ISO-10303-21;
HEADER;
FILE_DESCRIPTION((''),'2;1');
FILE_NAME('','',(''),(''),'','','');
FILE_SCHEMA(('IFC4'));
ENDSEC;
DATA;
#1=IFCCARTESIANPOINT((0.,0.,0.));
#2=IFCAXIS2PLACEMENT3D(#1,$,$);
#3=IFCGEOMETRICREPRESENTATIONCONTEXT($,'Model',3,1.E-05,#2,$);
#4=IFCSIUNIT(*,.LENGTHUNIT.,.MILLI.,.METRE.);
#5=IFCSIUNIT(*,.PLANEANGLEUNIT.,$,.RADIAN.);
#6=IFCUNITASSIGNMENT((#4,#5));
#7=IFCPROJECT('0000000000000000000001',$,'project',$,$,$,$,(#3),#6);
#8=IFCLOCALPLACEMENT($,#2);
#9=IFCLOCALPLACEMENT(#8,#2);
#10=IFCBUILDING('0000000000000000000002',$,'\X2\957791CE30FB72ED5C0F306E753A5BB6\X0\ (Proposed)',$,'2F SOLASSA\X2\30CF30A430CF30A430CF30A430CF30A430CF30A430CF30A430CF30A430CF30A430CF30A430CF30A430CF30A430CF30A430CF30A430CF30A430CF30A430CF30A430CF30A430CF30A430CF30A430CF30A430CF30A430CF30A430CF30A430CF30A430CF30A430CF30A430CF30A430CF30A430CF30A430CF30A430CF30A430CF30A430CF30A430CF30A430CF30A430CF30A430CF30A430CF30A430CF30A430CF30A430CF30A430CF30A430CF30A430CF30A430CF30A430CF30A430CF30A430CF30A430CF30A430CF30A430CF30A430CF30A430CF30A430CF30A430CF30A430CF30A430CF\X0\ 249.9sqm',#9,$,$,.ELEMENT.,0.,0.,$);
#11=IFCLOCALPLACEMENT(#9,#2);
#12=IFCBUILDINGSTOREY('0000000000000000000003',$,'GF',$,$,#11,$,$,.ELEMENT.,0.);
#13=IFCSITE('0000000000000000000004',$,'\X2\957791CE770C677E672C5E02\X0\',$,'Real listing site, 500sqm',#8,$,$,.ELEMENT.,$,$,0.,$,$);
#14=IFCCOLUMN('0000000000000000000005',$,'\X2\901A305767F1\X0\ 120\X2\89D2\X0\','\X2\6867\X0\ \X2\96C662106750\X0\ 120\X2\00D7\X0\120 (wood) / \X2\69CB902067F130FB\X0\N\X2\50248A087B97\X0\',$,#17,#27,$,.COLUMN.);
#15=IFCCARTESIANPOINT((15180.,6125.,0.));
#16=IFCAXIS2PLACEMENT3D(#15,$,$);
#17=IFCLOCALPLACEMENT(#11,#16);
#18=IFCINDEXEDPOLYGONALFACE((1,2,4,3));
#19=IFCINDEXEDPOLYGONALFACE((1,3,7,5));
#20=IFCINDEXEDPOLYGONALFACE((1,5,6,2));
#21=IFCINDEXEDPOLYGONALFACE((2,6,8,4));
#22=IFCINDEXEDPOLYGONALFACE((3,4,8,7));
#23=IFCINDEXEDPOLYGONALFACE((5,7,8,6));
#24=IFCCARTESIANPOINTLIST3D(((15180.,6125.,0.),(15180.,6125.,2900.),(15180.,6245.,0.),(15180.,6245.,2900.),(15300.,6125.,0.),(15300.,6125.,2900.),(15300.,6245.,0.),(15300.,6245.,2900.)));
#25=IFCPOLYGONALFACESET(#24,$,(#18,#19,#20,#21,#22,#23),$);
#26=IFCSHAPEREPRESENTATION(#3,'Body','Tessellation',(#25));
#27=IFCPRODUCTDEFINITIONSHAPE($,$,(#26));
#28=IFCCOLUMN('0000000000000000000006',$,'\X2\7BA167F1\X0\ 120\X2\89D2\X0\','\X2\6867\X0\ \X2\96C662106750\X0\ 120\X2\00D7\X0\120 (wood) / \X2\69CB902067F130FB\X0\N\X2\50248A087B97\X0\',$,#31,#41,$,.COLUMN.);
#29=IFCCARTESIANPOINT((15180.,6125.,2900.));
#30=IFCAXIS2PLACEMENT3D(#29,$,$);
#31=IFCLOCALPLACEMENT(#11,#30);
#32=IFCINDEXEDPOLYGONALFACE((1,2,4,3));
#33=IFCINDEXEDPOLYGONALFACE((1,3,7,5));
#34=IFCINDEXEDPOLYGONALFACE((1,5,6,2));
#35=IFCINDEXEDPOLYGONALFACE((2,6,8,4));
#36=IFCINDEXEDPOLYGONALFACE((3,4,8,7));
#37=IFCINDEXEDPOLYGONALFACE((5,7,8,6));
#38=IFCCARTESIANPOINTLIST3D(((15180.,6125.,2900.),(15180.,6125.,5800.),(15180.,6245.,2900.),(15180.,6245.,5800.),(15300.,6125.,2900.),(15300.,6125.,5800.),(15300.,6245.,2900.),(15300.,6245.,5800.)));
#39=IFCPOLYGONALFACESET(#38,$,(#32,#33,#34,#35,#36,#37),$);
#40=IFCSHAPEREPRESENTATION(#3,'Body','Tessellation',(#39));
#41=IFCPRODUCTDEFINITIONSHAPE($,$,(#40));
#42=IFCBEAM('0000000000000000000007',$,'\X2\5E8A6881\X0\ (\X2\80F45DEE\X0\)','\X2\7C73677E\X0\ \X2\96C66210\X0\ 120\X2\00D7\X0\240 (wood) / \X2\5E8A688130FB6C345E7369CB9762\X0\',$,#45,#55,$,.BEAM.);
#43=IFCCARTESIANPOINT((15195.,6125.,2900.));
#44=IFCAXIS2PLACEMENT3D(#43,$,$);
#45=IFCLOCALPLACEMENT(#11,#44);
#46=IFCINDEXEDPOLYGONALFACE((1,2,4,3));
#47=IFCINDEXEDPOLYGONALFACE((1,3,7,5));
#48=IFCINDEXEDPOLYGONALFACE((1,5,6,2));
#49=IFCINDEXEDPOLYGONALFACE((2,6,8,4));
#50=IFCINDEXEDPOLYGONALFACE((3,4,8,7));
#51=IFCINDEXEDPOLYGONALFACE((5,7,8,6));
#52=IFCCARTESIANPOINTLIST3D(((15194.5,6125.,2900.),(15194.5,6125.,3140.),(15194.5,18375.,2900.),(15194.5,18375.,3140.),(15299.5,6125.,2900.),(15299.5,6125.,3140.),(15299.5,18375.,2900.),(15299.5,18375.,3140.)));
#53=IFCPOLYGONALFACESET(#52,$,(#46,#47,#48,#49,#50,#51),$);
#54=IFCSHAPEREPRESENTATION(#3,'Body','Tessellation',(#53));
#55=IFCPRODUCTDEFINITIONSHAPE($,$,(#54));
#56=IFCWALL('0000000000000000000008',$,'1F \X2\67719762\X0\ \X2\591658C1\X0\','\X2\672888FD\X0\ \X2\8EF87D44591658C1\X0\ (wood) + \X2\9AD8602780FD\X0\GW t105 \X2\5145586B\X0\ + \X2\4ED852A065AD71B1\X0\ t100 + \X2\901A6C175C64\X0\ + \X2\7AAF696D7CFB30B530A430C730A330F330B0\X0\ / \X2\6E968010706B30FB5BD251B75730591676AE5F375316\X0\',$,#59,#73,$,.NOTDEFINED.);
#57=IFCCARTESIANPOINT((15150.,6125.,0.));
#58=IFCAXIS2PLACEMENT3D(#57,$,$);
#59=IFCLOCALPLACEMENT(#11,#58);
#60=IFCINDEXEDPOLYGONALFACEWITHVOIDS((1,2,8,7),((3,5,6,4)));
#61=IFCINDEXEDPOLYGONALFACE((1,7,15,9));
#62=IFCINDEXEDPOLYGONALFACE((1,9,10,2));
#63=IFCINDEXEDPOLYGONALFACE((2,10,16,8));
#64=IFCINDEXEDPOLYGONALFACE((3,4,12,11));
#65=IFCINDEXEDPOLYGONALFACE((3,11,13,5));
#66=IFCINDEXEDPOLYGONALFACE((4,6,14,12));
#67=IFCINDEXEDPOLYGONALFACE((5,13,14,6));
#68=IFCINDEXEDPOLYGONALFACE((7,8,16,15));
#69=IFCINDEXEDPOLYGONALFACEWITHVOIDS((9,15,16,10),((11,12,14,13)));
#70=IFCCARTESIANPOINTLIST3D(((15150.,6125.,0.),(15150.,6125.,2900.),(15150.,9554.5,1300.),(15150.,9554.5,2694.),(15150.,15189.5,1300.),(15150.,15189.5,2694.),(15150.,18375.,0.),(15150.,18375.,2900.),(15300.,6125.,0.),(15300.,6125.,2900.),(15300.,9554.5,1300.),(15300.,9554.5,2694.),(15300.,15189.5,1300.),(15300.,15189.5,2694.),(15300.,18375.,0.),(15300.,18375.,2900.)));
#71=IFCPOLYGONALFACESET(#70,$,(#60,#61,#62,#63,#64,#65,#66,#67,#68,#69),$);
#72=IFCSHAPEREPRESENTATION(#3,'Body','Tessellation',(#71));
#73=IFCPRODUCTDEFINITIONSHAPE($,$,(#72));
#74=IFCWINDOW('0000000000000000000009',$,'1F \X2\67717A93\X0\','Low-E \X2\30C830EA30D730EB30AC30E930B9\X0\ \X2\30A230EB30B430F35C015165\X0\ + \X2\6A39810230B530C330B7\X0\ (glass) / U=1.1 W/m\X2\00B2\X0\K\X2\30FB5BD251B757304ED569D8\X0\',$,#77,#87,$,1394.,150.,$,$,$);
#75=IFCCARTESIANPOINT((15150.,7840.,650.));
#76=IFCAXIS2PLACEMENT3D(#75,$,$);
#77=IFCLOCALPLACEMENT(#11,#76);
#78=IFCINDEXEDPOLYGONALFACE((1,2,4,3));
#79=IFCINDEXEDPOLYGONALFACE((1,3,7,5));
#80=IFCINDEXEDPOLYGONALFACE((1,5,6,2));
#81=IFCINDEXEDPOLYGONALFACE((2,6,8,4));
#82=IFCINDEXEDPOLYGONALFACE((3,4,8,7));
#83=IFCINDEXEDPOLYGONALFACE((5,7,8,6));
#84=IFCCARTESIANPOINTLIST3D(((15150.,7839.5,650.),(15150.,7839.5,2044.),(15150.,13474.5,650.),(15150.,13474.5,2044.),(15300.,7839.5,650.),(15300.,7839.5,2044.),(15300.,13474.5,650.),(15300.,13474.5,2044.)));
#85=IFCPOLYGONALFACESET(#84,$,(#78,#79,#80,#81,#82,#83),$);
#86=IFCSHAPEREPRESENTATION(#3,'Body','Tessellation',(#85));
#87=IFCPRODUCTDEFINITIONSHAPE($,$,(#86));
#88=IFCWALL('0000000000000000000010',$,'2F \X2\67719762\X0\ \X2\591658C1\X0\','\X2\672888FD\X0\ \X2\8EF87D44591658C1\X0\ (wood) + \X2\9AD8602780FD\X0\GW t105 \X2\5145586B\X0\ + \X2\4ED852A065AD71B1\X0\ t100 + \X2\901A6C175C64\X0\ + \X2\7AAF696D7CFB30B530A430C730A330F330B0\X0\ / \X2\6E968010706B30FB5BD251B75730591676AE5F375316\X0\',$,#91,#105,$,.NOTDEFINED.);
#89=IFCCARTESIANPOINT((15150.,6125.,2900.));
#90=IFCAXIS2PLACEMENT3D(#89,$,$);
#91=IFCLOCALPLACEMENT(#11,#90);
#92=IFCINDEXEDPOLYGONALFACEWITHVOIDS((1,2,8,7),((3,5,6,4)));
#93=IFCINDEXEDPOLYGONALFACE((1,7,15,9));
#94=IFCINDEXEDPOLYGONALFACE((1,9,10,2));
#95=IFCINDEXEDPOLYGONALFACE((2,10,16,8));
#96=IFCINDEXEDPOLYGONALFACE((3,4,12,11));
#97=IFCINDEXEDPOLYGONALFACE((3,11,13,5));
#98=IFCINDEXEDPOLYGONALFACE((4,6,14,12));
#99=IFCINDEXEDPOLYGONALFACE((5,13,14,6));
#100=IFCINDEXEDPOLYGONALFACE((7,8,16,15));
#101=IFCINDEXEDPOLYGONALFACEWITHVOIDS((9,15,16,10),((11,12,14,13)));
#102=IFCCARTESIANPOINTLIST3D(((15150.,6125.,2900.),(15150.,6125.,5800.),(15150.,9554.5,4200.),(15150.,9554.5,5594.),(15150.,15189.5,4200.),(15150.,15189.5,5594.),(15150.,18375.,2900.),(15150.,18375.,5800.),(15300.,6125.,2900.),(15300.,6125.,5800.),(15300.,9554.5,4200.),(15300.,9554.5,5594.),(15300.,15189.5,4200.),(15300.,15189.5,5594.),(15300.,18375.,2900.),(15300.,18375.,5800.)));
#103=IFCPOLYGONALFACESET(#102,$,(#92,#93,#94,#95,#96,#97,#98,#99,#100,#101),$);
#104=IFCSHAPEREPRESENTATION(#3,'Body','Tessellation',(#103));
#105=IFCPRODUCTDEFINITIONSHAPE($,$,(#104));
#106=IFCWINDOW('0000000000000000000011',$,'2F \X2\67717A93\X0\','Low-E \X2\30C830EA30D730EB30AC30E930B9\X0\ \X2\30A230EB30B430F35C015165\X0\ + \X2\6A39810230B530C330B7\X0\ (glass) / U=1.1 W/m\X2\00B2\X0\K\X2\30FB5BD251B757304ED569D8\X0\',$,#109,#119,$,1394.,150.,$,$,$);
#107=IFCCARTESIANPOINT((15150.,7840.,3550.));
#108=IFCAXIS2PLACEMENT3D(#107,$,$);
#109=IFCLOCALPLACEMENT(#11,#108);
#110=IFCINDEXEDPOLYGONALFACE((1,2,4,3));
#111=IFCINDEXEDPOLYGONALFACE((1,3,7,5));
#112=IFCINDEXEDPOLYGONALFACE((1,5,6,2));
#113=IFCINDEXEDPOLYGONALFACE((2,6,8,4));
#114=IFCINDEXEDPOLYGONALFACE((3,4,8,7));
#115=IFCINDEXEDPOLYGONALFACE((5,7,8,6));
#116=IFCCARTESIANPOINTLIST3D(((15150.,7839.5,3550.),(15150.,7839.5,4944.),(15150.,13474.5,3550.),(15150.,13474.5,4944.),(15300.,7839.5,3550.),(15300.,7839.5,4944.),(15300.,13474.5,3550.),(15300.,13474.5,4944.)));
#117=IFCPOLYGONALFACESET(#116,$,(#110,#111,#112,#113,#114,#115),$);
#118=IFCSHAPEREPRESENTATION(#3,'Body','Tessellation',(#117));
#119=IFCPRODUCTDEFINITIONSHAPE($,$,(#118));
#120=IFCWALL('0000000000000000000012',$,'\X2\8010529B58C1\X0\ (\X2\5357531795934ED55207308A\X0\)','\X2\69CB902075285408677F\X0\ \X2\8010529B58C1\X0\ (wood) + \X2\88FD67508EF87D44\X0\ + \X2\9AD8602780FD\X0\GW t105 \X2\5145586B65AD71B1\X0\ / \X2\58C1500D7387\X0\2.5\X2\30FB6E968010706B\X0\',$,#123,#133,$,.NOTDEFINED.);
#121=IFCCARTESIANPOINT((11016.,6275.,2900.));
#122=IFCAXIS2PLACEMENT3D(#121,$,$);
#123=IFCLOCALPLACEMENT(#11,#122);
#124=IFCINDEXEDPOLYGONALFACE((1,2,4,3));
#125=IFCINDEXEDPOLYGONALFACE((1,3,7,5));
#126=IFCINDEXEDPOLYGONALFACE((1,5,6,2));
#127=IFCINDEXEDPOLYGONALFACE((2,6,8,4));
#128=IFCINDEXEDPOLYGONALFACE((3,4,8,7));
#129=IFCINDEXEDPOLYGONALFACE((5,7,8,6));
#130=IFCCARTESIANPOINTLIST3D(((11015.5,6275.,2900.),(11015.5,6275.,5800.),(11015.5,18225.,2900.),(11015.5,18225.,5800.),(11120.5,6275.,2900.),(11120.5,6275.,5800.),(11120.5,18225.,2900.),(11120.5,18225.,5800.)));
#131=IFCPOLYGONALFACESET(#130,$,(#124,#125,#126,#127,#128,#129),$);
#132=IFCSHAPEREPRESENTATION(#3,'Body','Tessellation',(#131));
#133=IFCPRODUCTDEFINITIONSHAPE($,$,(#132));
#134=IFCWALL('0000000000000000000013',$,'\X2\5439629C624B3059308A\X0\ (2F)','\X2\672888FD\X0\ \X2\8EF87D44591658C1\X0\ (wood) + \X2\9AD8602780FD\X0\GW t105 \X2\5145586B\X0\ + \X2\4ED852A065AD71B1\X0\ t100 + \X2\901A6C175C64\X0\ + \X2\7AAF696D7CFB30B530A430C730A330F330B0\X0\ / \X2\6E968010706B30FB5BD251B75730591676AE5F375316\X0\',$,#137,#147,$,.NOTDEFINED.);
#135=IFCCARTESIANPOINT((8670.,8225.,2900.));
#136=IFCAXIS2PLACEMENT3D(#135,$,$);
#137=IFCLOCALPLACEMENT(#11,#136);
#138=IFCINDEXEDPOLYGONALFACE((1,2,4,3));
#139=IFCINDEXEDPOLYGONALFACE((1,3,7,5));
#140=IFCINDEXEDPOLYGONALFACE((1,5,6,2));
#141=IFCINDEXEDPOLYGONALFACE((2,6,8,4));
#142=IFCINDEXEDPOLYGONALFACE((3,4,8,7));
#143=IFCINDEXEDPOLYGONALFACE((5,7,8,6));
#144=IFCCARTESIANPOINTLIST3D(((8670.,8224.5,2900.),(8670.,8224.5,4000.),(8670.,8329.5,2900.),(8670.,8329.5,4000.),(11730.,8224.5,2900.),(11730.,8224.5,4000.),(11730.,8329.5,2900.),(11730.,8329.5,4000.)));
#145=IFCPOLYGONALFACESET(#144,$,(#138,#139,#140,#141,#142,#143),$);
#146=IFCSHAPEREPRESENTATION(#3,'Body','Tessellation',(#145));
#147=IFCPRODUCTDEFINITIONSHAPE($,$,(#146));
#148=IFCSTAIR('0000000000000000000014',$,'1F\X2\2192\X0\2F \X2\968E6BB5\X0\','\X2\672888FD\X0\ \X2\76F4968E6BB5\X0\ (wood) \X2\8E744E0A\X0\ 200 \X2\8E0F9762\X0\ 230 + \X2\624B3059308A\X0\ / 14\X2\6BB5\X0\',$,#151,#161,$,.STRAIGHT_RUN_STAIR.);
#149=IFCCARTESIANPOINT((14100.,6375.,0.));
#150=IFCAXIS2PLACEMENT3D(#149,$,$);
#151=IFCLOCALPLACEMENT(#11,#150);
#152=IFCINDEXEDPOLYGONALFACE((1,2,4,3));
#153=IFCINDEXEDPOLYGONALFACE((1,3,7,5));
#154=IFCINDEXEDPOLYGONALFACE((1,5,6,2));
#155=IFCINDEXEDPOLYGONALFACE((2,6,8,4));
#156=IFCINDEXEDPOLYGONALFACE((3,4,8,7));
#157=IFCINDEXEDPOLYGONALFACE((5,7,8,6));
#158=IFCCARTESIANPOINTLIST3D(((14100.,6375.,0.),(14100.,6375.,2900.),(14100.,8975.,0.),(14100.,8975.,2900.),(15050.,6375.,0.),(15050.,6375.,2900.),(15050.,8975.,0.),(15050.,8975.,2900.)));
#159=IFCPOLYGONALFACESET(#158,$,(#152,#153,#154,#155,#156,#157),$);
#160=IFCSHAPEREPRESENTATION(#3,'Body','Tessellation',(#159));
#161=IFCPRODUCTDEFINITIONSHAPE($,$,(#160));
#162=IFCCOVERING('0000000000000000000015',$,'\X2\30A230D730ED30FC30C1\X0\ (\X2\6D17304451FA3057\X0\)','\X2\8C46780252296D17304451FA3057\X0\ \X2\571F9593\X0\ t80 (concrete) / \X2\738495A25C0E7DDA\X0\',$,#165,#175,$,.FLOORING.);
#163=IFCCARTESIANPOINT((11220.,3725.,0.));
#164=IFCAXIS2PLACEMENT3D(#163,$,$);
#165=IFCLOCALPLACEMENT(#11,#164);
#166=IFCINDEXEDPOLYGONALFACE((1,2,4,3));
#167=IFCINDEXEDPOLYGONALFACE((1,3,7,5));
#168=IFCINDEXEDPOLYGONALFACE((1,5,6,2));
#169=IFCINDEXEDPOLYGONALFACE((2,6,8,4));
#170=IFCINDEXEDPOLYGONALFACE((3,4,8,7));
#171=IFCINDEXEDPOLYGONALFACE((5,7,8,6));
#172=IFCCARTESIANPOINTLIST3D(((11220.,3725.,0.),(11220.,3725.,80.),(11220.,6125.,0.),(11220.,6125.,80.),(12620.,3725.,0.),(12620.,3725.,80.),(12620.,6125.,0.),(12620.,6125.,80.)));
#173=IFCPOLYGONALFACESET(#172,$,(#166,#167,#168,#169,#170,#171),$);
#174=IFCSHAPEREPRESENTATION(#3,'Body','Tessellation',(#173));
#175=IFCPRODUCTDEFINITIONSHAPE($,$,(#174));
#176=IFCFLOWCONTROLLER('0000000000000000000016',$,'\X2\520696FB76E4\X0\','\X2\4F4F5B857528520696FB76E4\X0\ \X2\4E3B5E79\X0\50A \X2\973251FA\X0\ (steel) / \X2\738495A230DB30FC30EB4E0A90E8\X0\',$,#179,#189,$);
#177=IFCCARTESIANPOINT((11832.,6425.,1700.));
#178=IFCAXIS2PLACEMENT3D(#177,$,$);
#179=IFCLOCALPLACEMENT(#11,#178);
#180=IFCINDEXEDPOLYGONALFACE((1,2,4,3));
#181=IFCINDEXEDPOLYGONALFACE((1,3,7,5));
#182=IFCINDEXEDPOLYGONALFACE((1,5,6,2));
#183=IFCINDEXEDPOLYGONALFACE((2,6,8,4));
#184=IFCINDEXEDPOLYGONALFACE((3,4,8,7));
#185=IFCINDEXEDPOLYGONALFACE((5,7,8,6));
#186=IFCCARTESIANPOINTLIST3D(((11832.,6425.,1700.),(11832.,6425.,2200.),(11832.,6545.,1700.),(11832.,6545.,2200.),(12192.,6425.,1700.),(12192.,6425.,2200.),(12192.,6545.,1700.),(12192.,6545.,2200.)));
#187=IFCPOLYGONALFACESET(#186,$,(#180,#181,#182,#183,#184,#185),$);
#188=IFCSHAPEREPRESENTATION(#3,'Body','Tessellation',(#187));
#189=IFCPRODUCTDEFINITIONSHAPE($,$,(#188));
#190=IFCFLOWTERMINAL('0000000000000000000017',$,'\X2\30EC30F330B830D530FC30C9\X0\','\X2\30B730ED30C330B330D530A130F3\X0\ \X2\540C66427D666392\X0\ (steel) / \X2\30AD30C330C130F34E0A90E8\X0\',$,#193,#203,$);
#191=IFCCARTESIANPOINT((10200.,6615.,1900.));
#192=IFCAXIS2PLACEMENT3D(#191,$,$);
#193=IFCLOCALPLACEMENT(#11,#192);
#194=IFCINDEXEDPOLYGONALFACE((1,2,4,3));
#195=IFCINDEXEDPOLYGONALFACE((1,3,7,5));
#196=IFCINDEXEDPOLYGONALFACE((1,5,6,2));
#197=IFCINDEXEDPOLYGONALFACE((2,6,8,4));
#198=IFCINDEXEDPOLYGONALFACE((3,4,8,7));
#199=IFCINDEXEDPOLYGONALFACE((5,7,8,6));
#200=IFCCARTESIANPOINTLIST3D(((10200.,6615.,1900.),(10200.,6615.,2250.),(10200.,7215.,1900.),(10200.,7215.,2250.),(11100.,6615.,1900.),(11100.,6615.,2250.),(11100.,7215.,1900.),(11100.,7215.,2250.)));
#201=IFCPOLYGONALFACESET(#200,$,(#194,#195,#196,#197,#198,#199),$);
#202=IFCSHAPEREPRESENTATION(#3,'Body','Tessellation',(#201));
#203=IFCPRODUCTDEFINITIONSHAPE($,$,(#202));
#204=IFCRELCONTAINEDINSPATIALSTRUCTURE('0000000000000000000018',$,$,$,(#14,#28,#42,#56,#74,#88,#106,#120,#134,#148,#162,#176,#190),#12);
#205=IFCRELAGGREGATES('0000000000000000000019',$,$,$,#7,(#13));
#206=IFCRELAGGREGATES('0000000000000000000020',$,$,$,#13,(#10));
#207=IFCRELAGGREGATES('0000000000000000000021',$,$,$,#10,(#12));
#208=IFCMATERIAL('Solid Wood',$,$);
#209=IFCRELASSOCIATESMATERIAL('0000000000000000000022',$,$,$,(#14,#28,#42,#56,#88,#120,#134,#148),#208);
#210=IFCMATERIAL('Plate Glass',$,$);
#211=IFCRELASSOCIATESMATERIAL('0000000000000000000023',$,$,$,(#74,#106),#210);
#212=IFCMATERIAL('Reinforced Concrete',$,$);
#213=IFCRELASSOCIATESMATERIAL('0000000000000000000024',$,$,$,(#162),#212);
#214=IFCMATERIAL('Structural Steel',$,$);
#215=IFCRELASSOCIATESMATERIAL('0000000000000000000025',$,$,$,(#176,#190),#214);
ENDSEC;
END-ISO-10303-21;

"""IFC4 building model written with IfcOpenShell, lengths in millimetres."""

from ifc_helpers import new_model, si_unit, frame, frame_2d, origin, place, context, project, spatial, rectangle, extrude, material, element, fill, save


model = new_model("IFC4")

# Units and contexts
model_context = context("Model", 3, precision=1e-05, world=origin())
ifc_project = project(units=[si_unit("LENGTHUNIT", "METRE", prefix="MILLI"), si_unit("PLANEANGLEUNIT", "RADIAN")], contexts=[model_context])

# Site, building, storey
site_placement = place(None, origin())
site = spatial("IfcSite", under=ifc_project, at=site_placement, Name="長野県松本市", ObjectType="Real listing site, 500sqm", CompositionType="ELEMENT", RefElevation=0.0)
building_placement = place(site_placement, origin())
building = spatial("IfcBuilding", under=site, at=building_placement, Name="長野・狭小の町家 (Proposed)", ObjectType="2F SOLASSAハイハイハイハイハイハイハイハイハイハイハイハイハイハイハイハイハイハイハイハイハイハイハイハイハイハイハイハイハイハイハイハイハイハイハイハイハイハイハイハイハイハイハイハイハイハイハイハイハイハイハイハイハイハイハイハイハ 249.9sqm", CompositionType="ELEMENT", ElevationOfRefHeight=0.0, ElevationOfTerrain=0.0)
storey_placement = place(building_placement, origin())
storey = spatial("IfcBuildingStorey", under=building, at=storey_placement, Name="GF", CompositionType="ELEMENT", Elevation=0.0)

# Columns
ifc_material_1 = material(Name="Solid Wood")
column_1_placement = place(storey_placement, frame((15180.0, 6125.0, 0.0)))
element("IfcColumn", 1, at=column_1_placement, inside=storey, material=ifc_material_1, Name="通し柱 120角", Description="桧 集成材 120×120 (wood) / 構造柱・N値計算", PredefinedType="COLUMN", context=model_context, shape_type="SweptSolid", body=[
    extrude(rectangle(XDim=120.0, YDim=120.0, at=frame_2d((60.0, 60.0))), frame((15180.0, 6125.0, 0.0)), (0.0, 0.0, 1.0), 2900.0),
])
column_2_placement = place(storey_placement, frame((15180.0, 6125.0, 2900.0)))
element("IfcColumn", 2, at=column_2_placement, inside=storey, material=ifc_material_1, Name="管柱 120角", Description="桧 集成材 120×120 (wood) / 構造柱・N値計算", PredefinedType="COLUMN", context=model_context, shape_type="SweptSolid", body=[
    extrude(rectangle(XDim=120.0, YDim=120.0, at=frame_2d((60.0, 60.0))), frame((15180.0, 6125.0, 2900.0)), (0.0, 0.0, 1.0), 2900.0),
])

# Beam
beam_1_placement = place(storey_placement, frame((15195.0, 6125.0, 2900.0)))
element("IfcBeam", 3, at=beam_1_placement, inside=storey, material=ifc_material_1, Name="床梁 (胴差)", Description="米松 集成 120×240 (wood) / 床梁・水平構面", PredefinedType="BEAM", context=model_context, shape_type="SweptSolid", body=[
    extrude(rectangle(XDim=105.0, YDim=12250.0, at=frame_2d((52.0, 6125.0))), frame((15195.0, 6125.0, 2900.0)), (0.0, 0.0, 1.0), 240.0),
])

# Wall, opening, window
wall_1_placement = place(storey_placement, frame((15150.0, 6125.0, 0.0)))
wall_1 = element("IfcWall", 4, at=wall_1_placement, inside=storey, material=ifc_material_1, Name="1F 東面 外壁", Description="木製 軸組外壁 (wood) + 高性能GW t105 充填 + 付加断熱 t100 + 通気層 + 窯業系サイディング / 準耐火・寒冷地外皮強化", PredefinedType="NOTDEFINED", context=model_context, shape_type="SweptSolid", body=[
    extrude(rectangle(XDim=150.0, YDim=12250.0, at=frame_2d((75.0, 6125.0))), frame((15150.0, 6125.0, 0.0)), (0.0, 0.0, 1.0), 2900.0),
])
opening_1_placement = place(storey_placement, frame((15150.0, 7840.0, 650.0)))
opening_1 = element("IfcOpeningElement", 5, at=opening_1_placement, cuts=wall_1, PredefinedType="NOTDEFINED", context=model_context, shape_type="SweptSolid", body=[
    extrude(rectangle(XDim=150.0, YDim=5635.0, at=frame_2d((75.0, 2817.0))), frame((15150.0, 7840.0, 650.0)), (0.0, 0.0, 1.0), 1394.0),
])
ifc_material_2 = material(Name="Plate Glass")
window_1_placement = place(storey_placement, frame((15150.0, 7840.0, 650.0)))
window_1 = element("IfcWindow", 6, at=window_1_placement, inside=storey, material=ifc_material_2, Name="1F 東窓", Description="Low-E トリプルガラス アルゴン封入 + 樹脂サッシ (glass) / U=1.1 W/m²K・寒冷地仕様", OverallHeight=1394.0, OverallWidth=150.0, context=model_context, shape_type="SweptSolid", body=[
    extrude(rectangle(XDim=150.0, YDim=5635.0, at=frame_2d((75.0, 2817.0))), frame((15150.0, 7840.0, 650.0)), (0.0, 0.0, 1.0), 1394.0),
])
fill(opening_1, window_1)

# Wall, opening, window
wall_2_placement = place(storey_placement, frame((15150.0, 6125.0, 2900.0)))
wall_2 = element("IfcWall", 7, at=wall_2_placement, inside=storey, material=ifc_material_1, Name="2F 東面 外壁", Description="木製 軸組外壁 (wood) + 高性能GW t105 充填 + 付加断熱 t100 + 通気層 + 窯業系サイディング / 準耐火・寒冷地外皮強化", PredefinedType="NOTDEFINED", context=model_context, shape_type="SweptSolid", body=[
    extrude(rectangle(XDim=150.0, YDim=12250.0, at=frame_2d((75.0, 6125.0))), frame((15150.0, 6125.0, 2900.0)), (0.0, 0.0, 1.0), 2900.0),
])
opening_2_placement = place(storey_placement, frame((15150.0, 7840.0, 3550.0)))
opening_2 = element("IfcOpeningElement", 8, at=opening_2_placement, cuts=wall_2, PredefinedType="NOTDEFINED", context=model_context, shape_type="SweptSolid", body=[
    extrude(rectangle(XDim=150.0, YDim=5635.0, at=frame_2d((75.0, 2817.0))), frame((15150.0, 7840.0, 3550.0)), (0.0, 0.0, 1.0), 1394.0),
])
window_2_placement = place(storey_placement, frame((15150.0, 7840.0, 3550.0)))
window_2 = element("IfcWindow", 9, at=window_2_placement, inside=storey, material=ifc_material_2, Name="2F 東窓", Description="Low-E トリプルガラス アルゴン封入 + 樹脂サッシ (glass) / U=1.1 W/m²K・寒冷地仕様", OverallHeight=1394.0, OverallWidth=150.0, context=model_context, shape_type="SweptSolid", body=[
    extrude(rectangle(XDim=150.0, YDim=5635.0, at=frame_2d((75.0, 2817.0))), frame((15150.0, 7840.0, 3550.0)), (0.0, 0.0, 1.0), 1394.0),
])
fill(opening_2, window_2)

# Walls
wall_3_placement = place(storey_placement, frame((11016.0, 6275.0, 2900.0)))
element("IfcWall", 10, at=wall_3_placement, inside=storey, material=ifc_material_1, Name="耐力壁 (南北間仕切り)", Description="構造用合板 耐力壁 (wood) + 製材軸組 + 高性能GW t105 充填断熱 / 壁倍率2.5・準耐火", PredefinedType="NOTDEFINED", context=model_context, shape_type="SweptSolid", body=[
    extrude(rectangle(XDim=105.0, YDim=11950.0, at=frame_2d((52.0, 5975.0))), frame((11016.0, 6275.0, 2900.0)), (0.0, 0.0, 1.0), 2900.0),
])
wall_4_placement = place(storey_placement, frame((8670.0, 8225.0, 2900.0)))
element("IfcWall", 11, at=wall_4_placement, inside=storey, material=ifc_material_1, Name="吹抜手すり (2F)", Description="木製 軸組外壁 (wood) + 高性能GW t105 充填 + 付加断熱 t100 + 通気層 + 窯業系サイディング / 準耐火・寒冷地外皮強化", PredefinedType="NOTDEFINED", context=model_context, shape_type="SweptSolid", body=[
    extrude(rectangle(XDim=3060.0, YDim=105.0, at=frame_2d((1530.0, 52.0))), frame((8670.0, 8225.0, 2900.0)), (0.0, 0.0, 1.0), 1100.0),
])

# Stair
stair_placement = place(storey_placement, frame((14100.0, 6375.0, 0.0)))
element("IfcStair", 12, at=stair_placement, inside=storey, material=ifc_material_1, Name="1F→2F 階段", Description="木製 直階段 (wood) 蹴上 200 踏面 230 + 手すり / 14段", PredefinedType="STRAIGHT_RUN_STAIR", context=model_context, shape_type="SweptSolid", body=[
    extrude(rectangle(XDim=950.0, YDim=2600.0, at=frame_2d((475.0, 1300.0))), frame((14100.0, 6375.0, 0.0)), (0.0, 0.0, 1.0), 2900.0),
])

# Covering
ifc_material_3 = material(Name="Reinforced Concrete")
covering_placement = place(storey_placement, frame((11220.0, 3725.0, 0.0)))
element("IfcCovering", 13, at=covering_placement, inside=storey, material=ifc_material_3, Name="アプローチ (洗い出し)", Description="豆砂利洗い出し 土間 t80 (concrete) / 玄関導線", PredefinedType="FLOORING", context=model_context, shape_type="SweptSolid", body=[
    extrude(rectangle(XDim=1400.0, YDim=2400.0, at=frame_2d((700.0, 1200.0))), frame((11220.0, 3725.0, 0.0)), (0.0, 0.0, 1.0), 80.0),
])

# Flow controller
ifc_material_4 = material(Name="Structural Steel")
flow_controller_placement = place(storey_placement, frame((11832.0, 6425.0, 1700.0)))
element("IfcFlowController", 14, at=flow_controller_placement, inside=storey, material=ifc_material_4, Name="分電盤", Description="住宅用分電盤 主幹50A 露出 (steel) / 玄関ホール上部", context=model_context, shape_type="SweptSolid", body=[
    extrude(rectangle(XDim=360.0, YDim=120.0, at=frame_2d((180.0, 60.0))), frame((11832.0, 6425.0, 1700.0)), (0.0, 0.0, 1.0), 500.0),
])

# Flow terminal
flow_terminal_1_placement = place(storey_placement, frame((10200.0, 6615.0, 1900.0)))
element("IfcFlowTerminal", 15, at=flow_terminal_1_placement, inside=storey, material=ifc_material_4, Name="レンジフード", Description="シロッコファン 同時給排 (steel) / キッチン上部", context=model_context, shape_type="SweptSolid", body=[
    extrude(rectangle(XDim=900.0, YDim=600.0, at=frame_2d((450.0, 300.0))), frame((10200.0, 6615.0, 1900.0)), (0.0, 0.0, 1.0), 350.0),
])

save(model, "model.ifc")
